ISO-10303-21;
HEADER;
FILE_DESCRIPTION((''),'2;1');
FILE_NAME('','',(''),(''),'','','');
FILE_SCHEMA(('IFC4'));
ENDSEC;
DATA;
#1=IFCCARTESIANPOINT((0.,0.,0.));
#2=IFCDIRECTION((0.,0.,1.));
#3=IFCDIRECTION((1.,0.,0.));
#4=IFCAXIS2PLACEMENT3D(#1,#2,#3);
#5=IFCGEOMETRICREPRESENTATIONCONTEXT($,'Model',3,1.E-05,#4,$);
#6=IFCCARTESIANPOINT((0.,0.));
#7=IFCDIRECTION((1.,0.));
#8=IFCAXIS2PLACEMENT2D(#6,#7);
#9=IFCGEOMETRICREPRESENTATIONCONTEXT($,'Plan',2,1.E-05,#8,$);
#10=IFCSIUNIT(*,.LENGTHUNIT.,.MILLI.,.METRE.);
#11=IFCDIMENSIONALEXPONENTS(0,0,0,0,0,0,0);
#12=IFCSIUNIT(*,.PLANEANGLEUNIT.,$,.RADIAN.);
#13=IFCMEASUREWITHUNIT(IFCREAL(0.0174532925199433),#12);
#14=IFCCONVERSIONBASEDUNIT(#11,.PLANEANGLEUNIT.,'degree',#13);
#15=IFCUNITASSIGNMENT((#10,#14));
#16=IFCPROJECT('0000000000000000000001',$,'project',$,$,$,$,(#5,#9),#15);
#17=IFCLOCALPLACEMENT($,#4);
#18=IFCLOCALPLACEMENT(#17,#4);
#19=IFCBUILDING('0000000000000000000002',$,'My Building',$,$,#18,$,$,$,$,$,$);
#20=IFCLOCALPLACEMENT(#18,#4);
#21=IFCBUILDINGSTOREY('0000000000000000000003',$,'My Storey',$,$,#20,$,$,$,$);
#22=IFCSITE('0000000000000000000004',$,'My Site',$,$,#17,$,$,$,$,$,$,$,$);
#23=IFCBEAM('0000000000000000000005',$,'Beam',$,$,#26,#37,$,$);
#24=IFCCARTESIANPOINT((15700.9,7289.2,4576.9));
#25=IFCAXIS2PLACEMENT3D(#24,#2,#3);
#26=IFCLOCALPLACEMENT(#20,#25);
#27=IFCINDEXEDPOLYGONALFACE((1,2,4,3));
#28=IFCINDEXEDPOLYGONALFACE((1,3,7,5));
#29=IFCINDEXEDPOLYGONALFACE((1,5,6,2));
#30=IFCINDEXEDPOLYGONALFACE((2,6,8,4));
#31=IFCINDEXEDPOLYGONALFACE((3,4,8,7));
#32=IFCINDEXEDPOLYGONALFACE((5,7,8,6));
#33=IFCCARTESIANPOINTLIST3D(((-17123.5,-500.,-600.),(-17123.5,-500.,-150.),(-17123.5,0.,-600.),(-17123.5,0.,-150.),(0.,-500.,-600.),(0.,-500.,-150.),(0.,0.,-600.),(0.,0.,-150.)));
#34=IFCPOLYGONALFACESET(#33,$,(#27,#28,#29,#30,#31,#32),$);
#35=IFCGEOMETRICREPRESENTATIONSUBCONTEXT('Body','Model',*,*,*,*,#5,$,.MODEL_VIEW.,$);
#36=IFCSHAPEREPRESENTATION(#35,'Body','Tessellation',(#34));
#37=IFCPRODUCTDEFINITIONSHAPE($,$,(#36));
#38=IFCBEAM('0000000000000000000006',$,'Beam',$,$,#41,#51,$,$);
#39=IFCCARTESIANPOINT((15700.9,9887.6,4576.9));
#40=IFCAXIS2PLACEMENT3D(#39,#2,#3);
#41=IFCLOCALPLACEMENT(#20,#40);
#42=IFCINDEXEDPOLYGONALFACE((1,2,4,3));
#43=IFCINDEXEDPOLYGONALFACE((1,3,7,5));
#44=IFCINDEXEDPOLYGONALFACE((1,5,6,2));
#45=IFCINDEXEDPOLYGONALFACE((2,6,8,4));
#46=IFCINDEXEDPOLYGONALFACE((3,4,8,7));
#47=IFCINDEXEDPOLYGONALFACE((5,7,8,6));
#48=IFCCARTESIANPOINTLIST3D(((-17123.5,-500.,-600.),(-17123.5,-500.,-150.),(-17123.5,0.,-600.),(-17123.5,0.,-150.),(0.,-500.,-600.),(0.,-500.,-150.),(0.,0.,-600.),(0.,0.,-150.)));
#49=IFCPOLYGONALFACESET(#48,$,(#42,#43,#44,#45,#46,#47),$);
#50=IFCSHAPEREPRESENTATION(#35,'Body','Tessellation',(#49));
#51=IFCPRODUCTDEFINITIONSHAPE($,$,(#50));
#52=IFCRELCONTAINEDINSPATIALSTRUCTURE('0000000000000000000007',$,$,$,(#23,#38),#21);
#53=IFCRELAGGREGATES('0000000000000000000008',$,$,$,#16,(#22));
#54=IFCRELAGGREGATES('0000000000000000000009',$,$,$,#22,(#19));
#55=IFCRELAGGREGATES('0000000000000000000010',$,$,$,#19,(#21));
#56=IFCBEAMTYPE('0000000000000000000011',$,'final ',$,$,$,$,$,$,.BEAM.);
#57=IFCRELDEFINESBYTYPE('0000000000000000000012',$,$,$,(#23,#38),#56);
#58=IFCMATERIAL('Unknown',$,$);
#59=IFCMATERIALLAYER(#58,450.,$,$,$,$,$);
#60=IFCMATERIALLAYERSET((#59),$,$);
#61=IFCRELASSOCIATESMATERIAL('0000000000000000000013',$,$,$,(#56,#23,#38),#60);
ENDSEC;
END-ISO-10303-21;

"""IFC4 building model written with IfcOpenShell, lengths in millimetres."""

from ifc_helpers import new_model, entity, si_unit, converted_unit, frame, origin_with_axes, origin_2d_with_axis, place, context, subcontext, project, spatial, indexed_curve, outline, extrude, material, layer, layer_set, layer_usage, type_object, element, save


model = new_model("IFC4")

# Units and contexts
model_context = context("Model", 3, precision=1e-05, world=origin_with_axes())
plan_context = context("Plan", 2, precision=1e-05, world=origin_2d_with_axis())
body_context = subcontext(model_context, "Body", "Model", "MODEL_VIEW")
ifc_project = project(units=[si_unit("LENGTHUNIT", "METRE", prefix="MILLI"), converted_unit("PLANEANGLEUNIT", "degree", entity("IfcReal", 0.0174532925199433), si_unit("PLANEANGLEUNIT", "RADIAN"), dimensions=[0, 0, 0, 0, 0, 0, 0])], contexts=[model_context, plan_context])

# Site, building, storey
site_placement = place(None, origin_with_axes())
site = spatial("IfcSite", under=ifc_project, at=site_placement, Name="My Site")
building_placement = place(site_placement, origin_with_axes())
building = spatial("IfcBuilding", under=site, at=building_placement, Name="My Building")
storey_placement = place(building_placement, origin_with_axes())
storey = spatial("IfcBuildingStorey", under=building, at=storey_placement, Name="My Storey")

# Shared definitions
ifc_material = material(Name="Unknown")

# Beams
ifc_layer_1 = layer(ifc_material, 450.0)
ifc_layer_set_1 = layer_set([ifc_layer_1])
ifc_layer_usage_1 = layer_usage(ifc_layer_set_1, "AXIS3", "POSITIVE", -600.0)
beam_type = type_object("IfcBeamType", Name="final ", PredefinedType="BEAM", material=ifc_layer_set_1)
beam_1_placement = place(storey_placement, frame((15700.9, 7289.2, 4576.9), z_axis=(0.0, 0.0, 1.0), x_axis=(1.0, 0.0, 0.0)))
element("IfcBeam", 1, at=beam_1_placement, inside=storey, type_object=beam_type, material=ifc_layer_usage_1, Name="Beam", context=body_context, shape_type="SweptSolid", body=[
    extrude(outline(indexed_curve([(0.0, 0.0), (0.0, -500.0), (-17123.5, -500.0), (-17123.5, 0.0), (0.0, 0.0)])), frame((0.0, 0.0, -600.0), z_axis=(0.0, 0.0, 1.0), x_axis=(1.0, 0.0, 0.0)), (0.0, 0.0, 1.0), 450.0),
])
ifc_layer_usage_2 = layer_usage(ifc_layer_set_1, "AXIS3", "POSITIVE", -600.0)
beam_2_placement = place(storey_placement, frame((15700.9, 9887.6, 4576.9), z_axis=(0.0, 0.0, 1.0), x_axis=(1.0, 0.0, 0.0)))
element("IfcBeam", 2, at=beam_2_placement, inside=storey, type_object=beam_type, material=ifc_layer_usage_2, Name="Beam", context=body_context, shape_type="SweptSolid", body=[
    extrude(outline(indexed_curve([(0.0, 0.0), (0.0, -500.0), (-17123.5, -500.0), (-17123.5, 0.0), (0.0, 0.0)])), frame((0.0, 0.0, -600.0), z_axis=(0.0, 0.0, 1.0), x_axis=(1.0, 0.0, 0.0)), (0.0, 0.0, 1.0), 450.0),
])

save(model, "model.ifc")
